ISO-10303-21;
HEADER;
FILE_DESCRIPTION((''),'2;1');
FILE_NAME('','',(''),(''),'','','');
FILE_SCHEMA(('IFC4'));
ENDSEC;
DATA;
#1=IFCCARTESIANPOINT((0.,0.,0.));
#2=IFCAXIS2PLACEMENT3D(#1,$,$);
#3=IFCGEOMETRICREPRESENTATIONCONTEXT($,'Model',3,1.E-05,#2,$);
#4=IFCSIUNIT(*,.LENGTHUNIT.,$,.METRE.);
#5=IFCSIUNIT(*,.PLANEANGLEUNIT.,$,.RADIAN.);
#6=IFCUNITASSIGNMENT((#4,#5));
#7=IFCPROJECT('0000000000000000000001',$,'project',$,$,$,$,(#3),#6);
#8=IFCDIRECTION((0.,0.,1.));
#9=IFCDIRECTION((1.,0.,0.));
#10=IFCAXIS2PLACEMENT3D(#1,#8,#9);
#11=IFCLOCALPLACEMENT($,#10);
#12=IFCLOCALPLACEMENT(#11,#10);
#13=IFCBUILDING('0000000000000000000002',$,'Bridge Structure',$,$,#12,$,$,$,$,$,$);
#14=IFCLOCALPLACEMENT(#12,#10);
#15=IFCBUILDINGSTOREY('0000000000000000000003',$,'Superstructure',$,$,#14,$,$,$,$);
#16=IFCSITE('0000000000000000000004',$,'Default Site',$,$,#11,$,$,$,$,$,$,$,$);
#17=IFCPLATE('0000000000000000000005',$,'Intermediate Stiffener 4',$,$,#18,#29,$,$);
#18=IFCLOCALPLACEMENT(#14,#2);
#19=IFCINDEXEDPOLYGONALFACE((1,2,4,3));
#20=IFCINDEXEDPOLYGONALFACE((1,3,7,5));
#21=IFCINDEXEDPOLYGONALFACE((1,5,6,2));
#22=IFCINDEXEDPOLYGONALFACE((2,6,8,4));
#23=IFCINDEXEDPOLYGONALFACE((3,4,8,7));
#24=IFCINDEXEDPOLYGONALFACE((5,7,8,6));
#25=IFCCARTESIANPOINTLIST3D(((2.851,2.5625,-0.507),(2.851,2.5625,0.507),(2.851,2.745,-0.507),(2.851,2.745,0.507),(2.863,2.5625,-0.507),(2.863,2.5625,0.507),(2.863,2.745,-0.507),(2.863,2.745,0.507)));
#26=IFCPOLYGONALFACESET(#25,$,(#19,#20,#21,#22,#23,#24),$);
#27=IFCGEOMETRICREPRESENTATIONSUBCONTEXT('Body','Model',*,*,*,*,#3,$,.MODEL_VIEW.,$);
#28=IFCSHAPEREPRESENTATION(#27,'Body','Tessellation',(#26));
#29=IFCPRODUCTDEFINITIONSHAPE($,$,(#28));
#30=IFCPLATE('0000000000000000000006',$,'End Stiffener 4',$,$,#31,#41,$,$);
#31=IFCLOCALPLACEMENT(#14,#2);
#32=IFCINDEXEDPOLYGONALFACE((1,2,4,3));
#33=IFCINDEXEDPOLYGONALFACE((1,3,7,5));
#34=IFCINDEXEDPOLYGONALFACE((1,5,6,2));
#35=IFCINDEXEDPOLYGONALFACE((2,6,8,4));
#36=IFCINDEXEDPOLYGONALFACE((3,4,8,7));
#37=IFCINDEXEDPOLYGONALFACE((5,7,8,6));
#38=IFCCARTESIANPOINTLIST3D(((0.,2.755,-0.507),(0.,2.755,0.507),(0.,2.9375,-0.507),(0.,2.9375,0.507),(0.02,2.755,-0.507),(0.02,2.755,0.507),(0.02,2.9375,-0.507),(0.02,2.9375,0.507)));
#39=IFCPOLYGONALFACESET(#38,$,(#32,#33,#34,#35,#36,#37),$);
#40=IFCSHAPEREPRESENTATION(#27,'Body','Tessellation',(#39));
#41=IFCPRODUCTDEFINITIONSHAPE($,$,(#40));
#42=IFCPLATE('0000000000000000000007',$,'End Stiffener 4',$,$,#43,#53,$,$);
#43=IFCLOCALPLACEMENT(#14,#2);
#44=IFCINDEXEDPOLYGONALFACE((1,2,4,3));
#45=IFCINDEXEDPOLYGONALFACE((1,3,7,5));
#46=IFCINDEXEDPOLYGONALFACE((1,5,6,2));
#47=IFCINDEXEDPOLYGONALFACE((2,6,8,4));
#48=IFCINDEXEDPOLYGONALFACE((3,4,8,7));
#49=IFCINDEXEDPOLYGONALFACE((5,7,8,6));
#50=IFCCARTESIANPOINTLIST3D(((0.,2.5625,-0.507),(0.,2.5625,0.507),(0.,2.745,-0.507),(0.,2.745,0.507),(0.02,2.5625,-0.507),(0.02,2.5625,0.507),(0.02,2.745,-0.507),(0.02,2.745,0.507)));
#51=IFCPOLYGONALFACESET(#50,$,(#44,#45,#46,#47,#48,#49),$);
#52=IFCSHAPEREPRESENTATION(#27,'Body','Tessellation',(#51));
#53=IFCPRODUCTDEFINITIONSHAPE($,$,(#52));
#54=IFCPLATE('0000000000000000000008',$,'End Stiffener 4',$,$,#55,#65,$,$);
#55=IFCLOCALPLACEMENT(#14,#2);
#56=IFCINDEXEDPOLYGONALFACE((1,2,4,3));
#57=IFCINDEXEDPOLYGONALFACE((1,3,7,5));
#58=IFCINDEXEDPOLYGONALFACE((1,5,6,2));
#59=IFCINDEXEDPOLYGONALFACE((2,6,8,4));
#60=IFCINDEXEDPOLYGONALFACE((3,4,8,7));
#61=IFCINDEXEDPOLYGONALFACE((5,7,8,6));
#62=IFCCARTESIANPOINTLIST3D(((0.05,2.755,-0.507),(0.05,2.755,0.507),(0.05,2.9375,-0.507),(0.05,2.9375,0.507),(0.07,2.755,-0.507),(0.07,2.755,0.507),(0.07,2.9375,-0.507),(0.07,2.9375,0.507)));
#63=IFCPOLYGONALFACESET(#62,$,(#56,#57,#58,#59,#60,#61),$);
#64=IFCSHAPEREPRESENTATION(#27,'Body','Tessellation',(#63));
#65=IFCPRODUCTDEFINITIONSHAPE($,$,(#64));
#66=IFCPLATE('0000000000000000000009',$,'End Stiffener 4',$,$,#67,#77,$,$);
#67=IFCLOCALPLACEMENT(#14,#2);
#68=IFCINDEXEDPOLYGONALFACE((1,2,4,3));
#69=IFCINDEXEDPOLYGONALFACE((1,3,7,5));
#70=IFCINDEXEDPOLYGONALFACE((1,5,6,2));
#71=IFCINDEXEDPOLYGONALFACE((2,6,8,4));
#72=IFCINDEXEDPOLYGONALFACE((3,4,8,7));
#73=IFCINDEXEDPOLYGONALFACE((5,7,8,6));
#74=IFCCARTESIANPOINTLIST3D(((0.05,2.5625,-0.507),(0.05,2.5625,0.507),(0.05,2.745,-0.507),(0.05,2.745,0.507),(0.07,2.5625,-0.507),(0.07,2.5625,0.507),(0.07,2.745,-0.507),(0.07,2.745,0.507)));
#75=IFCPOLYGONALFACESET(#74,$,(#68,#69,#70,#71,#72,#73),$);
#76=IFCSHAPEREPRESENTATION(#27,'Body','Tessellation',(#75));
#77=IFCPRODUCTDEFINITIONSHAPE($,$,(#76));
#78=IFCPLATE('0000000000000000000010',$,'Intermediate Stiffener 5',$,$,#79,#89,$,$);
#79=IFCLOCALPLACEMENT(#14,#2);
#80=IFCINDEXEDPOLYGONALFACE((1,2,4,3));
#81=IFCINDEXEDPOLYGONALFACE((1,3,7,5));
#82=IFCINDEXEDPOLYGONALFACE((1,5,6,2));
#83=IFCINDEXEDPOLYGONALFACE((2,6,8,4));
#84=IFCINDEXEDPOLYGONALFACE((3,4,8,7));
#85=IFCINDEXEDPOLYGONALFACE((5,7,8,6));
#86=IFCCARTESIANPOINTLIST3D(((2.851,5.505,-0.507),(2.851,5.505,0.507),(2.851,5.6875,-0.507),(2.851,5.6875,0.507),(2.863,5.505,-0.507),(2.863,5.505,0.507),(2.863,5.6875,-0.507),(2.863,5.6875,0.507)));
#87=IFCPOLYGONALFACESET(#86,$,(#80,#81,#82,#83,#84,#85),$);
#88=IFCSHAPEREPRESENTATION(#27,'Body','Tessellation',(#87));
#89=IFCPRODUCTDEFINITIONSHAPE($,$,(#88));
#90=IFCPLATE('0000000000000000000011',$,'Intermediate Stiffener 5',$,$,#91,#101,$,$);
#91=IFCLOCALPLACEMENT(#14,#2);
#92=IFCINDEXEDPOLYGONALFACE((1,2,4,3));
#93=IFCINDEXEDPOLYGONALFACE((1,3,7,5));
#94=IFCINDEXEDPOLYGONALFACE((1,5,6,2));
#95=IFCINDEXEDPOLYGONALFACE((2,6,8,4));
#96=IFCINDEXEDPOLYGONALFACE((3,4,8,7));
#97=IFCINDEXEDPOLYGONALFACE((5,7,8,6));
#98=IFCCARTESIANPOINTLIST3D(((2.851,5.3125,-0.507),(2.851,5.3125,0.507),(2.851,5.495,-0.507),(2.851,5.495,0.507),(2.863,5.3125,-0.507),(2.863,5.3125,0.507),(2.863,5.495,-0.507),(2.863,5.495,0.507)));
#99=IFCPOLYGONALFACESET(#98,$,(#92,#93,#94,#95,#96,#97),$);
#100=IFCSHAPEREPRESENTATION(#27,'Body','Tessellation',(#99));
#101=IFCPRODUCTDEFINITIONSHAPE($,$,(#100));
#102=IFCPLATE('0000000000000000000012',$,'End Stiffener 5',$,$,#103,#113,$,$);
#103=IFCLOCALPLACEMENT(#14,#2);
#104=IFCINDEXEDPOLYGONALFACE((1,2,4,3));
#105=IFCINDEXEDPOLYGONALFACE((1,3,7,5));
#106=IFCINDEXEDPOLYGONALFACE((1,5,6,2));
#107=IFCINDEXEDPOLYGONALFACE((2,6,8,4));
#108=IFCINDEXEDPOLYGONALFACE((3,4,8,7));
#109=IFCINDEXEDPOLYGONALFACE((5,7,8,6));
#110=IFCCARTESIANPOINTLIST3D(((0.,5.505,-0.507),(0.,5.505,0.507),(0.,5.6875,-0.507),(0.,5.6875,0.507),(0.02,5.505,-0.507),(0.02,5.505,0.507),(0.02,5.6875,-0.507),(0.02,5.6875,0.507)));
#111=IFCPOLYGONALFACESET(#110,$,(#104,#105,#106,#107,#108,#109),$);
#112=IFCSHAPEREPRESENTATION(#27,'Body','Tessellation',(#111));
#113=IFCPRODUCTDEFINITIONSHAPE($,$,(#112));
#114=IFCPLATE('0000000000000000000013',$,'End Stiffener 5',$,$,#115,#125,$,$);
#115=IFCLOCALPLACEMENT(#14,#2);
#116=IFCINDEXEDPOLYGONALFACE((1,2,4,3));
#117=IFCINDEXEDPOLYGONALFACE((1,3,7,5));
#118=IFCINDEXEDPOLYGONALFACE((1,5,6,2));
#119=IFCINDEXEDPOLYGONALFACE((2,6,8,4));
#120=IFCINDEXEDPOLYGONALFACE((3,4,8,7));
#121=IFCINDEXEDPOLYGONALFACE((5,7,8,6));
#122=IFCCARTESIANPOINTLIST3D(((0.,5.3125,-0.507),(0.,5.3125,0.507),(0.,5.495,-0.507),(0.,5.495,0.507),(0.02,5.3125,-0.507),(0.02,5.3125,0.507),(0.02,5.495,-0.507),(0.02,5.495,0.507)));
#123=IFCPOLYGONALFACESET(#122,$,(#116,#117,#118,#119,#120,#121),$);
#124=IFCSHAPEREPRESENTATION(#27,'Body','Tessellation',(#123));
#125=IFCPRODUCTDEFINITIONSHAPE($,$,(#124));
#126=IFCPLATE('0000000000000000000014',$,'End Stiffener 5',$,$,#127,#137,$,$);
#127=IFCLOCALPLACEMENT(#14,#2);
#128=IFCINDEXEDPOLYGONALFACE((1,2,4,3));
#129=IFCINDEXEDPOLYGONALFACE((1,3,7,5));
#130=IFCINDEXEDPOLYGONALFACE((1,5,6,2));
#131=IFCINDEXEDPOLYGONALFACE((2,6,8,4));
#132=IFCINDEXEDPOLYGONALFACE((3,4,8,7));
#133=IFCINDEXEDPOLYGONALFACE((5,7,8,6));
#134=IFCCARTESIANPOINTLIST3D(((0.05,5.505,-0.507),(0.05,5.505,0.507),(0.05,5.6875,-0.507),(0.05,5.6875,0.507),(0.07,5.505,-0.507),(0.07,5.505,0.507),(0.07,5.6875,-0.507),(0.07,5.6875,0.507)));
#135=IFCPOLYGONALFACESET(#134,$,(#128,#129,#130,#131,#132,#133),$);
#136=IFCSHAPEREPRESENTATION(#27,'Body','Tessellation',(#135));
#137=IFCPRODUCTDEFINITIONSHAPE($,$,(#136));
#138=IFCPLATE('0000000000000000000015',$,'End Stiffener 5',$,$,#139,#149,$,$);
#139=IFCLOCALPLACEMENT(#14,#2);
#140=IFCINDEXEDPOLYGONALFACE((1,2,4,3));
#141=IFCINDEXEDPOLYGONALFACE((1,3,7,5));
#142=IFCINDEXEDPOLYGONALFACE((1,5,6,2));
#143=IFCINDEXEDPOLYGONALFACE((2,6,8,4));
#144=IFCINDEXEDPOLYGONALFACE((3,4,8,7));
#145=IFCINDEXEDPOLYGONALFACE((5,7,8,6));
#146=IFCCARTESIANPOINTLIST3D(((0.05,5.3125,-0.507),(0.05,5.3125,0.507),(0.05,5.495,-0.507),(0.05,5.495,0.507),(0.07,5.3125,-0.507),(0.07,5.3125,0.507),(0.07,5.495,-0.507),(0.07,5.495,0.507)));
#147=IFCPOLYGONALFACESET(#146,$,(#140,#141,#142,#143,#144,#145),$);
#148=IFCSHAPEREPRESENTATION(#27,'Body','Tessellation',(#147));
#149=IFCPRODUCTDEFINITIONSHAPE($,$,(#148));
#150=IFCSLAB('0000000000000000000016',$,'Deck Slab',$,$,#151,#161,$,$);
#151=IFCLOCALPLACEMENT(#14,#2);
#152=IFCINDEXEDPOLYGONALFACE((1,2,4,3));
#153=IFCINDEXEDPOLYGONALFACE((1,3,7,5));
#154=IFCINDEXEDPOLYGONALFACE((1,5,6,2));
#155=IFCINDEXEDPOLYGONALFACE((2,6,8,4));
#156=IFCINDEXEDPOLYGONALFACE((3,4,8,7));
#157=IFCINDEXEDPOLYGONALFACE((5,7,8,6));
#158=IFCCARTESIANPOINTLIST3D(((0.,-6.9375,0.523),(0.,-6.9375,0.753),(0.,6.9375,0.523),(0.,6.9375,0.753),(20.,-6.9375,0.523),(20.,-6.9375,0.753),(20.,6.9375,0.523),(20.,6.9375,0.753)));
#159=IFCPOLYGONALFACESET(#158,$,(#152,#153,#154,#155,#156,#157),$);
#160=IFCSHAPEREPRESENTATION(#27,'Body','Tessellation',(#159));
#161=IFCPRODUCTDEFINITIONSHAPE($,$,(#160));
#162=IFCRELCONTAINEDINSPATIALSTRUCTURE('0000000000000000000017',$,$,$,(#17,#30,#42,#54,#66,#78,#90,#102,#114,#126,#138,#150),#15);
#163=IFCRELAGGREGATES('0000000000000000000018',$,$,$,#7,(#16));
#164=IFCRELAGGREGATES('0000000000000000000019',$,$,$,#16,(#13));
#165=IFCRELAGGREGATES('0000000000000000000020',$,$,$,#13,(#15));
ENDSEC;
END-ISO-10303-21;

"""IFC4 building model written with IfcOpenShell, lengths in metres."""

from ifc_helpers import new_model, si_unit, frame, origin, origin_with_axes, origin_2d_with_axis, place, context, subcontext, project, spatial, polyline, rectangle, outline, extrude, element, save


model = new_model("IFC4")

# Units and contexts
model_context = context("Model", 3, precision=1e-05, world=origin())
body_context = subcontext(model_context, "Body", "Model", "MODEL_VIEW")
ifc_project = project(units=[si_unit("LENGTHUNIT", "METRE"), si_unit("PLANEANGLEUNIT", "RADIAN")], contexts=[model_context])

# Site, building, storey
site_placement = place(None, origin_with_axes())
site = spatial("IfcSite", under=ifc_project, at=site_placement, Name="Default Site")
building_placement = place(site_placement, origin_with_axes())
building = spatial("IfcBuilding", under=site, at=building_placement, Name="Bridge Structure")
storey_placement = place(building_placement, origin_with_axes())
storey = spatial("IfcBuildingStorey", under=building, at=storey_placement, Name="Superstructure")

# Plates
for number, where, z_axis, x_axis, name in (
    (1, (2.857, 2.6538, -0.507), (0.0, 0.0, 1.0), (1.0, 0.0, 0.0), "Intermediate Stiffener 4"),
):
    element("IfcPlate", number, at=place(storey_placement, frame(where, z_axis=z_axis, x_axis=x_axis)), inside=storey, Name=name, context=body_context, shape_type="SweptSolid", body=[
        extrude(rectangle(XDim=0.012, YDim=0.1825, at=origin_2d_with_axis()), origin_with_axes(), (0.0, 0.0, 1.0), 1.014),
    ])
for number, where, z_axis, x_axis, name in (
    (2, (0.01, 2.8462, -0.507), (0.0, 0.0, 1.0), (1.0, 0.0, 0.0), "End Stiffener 4"),
    (3, (0.01, 2.6538, -0.507), (0.0, 0.0, 1.0), (1.0, 0.0, 0.0), "End Stiffener 4"),
    (4, (0.06, 2.8462, -0.507), (0.0, 0.0, 1.0), (1.0, 0.0, 0.0), "End Stiffener 4"),
    (5, (0.06, 2.6538, -0.507), (0.0, 0.0, 1.0), (1.0, 0.0, 0.0), "End Stiffener 4"),
):
    element("IfcPlate", number, at=place(storey_placement, frame(where, z_axis=z_axis, x_axis=x_axis)), inside=storey, Name=name, context=body_context, shape_type="SweptSolid", body=[
        extrude(rectangle(XDim=0.02, YDim=0.1825, at=origin_2d_with_axis()), origin_with_axes(), (0.0, 0.0, 1.0), 1.014),
    ])
for number, where, z_axis, x_axis, name in (
    (6, (2.857, 5.5963, -0.507), (0.0, 0.0, 1.0), (1.0, 0.0, 0.0), "Intermediate Stiffener 5"),
    (7, (2.857, 5.4038, -0.507), (0.0, 0.0, 1.0), (1.0, 0.0, 0.0), "Intermediate Stiffener 5"),
):
    element("IfcPlate", number, at=place(storey_placement, frame(where, z_axis=z_axis, x_axis=x_axis)), inside=storey, Name=name, context=body_context, shape_type="SweptSolid", body=[
        extrude(rectangle(XDim=0.012, YDim=0.1825, at=origin_2d_with_axis()), origin_with_axes(), (0.0, 0.0, 1.0), 1.014),
    ])
for number, where, z_axis, x_axis, name in (
    (8, (0.01, 5.5963, -0.507), (0.0, 0.0, 1.0), (1.0, 0.0, 0.0), "End Stiffener 5"),
    (9, (0.01, 5.4038, -0.507), (0.0, 0.0, 1.0), (1.0, 0.0, 0.0), "End Stiffener 5"),
    (10, (0.06, 5.5963, -0.507), (0.0, 0.0, 1.0), (1.0, 0.0, 0.0), "End Stiffener 5"),
    (11, (0.06, 5.4038, -0.507), (0.0, 0.0, 1.0), (1.0, 0.0, 0.0), "End Stiffener 5"),
):
    element("IfcPlate", number, at=place(storey_placement, frame(where, z_axis=z_axis, x_axis=x_axis)), inside=storey, Name=name, context=body_context, shape_type="SweptSolid", body=[
        extrude(rectangle(XDim=0.02, YDim=0.1825, at=origin_2d_with_axis()), origin_with_axes(), (0.0, 0.0, 1.0), 1.014),
    ])

# Slab
slab_placement = place(storey_placement, frame((0.0, 0.0, 0.523), z_axis=(0.0, 0.0, 1.0), x_axis=(1.0, 0.0, 0.0)))
element("IfcSlab", 12, at=slab_placement, inside=storey, Name="Deck Slab", context=body_context, shape_type="SweptSolid", body=[
    extrude(outline(polyline([(0.0, -6.9375), (20.0, -6.9375), (20.0, 6.9375), (0.0, 6.9375), (0.0, -6.9375)])), origin_with_axes(), (0.0, 0.0, 1.0), 0.23),
])

save(model, "model.ifc")
